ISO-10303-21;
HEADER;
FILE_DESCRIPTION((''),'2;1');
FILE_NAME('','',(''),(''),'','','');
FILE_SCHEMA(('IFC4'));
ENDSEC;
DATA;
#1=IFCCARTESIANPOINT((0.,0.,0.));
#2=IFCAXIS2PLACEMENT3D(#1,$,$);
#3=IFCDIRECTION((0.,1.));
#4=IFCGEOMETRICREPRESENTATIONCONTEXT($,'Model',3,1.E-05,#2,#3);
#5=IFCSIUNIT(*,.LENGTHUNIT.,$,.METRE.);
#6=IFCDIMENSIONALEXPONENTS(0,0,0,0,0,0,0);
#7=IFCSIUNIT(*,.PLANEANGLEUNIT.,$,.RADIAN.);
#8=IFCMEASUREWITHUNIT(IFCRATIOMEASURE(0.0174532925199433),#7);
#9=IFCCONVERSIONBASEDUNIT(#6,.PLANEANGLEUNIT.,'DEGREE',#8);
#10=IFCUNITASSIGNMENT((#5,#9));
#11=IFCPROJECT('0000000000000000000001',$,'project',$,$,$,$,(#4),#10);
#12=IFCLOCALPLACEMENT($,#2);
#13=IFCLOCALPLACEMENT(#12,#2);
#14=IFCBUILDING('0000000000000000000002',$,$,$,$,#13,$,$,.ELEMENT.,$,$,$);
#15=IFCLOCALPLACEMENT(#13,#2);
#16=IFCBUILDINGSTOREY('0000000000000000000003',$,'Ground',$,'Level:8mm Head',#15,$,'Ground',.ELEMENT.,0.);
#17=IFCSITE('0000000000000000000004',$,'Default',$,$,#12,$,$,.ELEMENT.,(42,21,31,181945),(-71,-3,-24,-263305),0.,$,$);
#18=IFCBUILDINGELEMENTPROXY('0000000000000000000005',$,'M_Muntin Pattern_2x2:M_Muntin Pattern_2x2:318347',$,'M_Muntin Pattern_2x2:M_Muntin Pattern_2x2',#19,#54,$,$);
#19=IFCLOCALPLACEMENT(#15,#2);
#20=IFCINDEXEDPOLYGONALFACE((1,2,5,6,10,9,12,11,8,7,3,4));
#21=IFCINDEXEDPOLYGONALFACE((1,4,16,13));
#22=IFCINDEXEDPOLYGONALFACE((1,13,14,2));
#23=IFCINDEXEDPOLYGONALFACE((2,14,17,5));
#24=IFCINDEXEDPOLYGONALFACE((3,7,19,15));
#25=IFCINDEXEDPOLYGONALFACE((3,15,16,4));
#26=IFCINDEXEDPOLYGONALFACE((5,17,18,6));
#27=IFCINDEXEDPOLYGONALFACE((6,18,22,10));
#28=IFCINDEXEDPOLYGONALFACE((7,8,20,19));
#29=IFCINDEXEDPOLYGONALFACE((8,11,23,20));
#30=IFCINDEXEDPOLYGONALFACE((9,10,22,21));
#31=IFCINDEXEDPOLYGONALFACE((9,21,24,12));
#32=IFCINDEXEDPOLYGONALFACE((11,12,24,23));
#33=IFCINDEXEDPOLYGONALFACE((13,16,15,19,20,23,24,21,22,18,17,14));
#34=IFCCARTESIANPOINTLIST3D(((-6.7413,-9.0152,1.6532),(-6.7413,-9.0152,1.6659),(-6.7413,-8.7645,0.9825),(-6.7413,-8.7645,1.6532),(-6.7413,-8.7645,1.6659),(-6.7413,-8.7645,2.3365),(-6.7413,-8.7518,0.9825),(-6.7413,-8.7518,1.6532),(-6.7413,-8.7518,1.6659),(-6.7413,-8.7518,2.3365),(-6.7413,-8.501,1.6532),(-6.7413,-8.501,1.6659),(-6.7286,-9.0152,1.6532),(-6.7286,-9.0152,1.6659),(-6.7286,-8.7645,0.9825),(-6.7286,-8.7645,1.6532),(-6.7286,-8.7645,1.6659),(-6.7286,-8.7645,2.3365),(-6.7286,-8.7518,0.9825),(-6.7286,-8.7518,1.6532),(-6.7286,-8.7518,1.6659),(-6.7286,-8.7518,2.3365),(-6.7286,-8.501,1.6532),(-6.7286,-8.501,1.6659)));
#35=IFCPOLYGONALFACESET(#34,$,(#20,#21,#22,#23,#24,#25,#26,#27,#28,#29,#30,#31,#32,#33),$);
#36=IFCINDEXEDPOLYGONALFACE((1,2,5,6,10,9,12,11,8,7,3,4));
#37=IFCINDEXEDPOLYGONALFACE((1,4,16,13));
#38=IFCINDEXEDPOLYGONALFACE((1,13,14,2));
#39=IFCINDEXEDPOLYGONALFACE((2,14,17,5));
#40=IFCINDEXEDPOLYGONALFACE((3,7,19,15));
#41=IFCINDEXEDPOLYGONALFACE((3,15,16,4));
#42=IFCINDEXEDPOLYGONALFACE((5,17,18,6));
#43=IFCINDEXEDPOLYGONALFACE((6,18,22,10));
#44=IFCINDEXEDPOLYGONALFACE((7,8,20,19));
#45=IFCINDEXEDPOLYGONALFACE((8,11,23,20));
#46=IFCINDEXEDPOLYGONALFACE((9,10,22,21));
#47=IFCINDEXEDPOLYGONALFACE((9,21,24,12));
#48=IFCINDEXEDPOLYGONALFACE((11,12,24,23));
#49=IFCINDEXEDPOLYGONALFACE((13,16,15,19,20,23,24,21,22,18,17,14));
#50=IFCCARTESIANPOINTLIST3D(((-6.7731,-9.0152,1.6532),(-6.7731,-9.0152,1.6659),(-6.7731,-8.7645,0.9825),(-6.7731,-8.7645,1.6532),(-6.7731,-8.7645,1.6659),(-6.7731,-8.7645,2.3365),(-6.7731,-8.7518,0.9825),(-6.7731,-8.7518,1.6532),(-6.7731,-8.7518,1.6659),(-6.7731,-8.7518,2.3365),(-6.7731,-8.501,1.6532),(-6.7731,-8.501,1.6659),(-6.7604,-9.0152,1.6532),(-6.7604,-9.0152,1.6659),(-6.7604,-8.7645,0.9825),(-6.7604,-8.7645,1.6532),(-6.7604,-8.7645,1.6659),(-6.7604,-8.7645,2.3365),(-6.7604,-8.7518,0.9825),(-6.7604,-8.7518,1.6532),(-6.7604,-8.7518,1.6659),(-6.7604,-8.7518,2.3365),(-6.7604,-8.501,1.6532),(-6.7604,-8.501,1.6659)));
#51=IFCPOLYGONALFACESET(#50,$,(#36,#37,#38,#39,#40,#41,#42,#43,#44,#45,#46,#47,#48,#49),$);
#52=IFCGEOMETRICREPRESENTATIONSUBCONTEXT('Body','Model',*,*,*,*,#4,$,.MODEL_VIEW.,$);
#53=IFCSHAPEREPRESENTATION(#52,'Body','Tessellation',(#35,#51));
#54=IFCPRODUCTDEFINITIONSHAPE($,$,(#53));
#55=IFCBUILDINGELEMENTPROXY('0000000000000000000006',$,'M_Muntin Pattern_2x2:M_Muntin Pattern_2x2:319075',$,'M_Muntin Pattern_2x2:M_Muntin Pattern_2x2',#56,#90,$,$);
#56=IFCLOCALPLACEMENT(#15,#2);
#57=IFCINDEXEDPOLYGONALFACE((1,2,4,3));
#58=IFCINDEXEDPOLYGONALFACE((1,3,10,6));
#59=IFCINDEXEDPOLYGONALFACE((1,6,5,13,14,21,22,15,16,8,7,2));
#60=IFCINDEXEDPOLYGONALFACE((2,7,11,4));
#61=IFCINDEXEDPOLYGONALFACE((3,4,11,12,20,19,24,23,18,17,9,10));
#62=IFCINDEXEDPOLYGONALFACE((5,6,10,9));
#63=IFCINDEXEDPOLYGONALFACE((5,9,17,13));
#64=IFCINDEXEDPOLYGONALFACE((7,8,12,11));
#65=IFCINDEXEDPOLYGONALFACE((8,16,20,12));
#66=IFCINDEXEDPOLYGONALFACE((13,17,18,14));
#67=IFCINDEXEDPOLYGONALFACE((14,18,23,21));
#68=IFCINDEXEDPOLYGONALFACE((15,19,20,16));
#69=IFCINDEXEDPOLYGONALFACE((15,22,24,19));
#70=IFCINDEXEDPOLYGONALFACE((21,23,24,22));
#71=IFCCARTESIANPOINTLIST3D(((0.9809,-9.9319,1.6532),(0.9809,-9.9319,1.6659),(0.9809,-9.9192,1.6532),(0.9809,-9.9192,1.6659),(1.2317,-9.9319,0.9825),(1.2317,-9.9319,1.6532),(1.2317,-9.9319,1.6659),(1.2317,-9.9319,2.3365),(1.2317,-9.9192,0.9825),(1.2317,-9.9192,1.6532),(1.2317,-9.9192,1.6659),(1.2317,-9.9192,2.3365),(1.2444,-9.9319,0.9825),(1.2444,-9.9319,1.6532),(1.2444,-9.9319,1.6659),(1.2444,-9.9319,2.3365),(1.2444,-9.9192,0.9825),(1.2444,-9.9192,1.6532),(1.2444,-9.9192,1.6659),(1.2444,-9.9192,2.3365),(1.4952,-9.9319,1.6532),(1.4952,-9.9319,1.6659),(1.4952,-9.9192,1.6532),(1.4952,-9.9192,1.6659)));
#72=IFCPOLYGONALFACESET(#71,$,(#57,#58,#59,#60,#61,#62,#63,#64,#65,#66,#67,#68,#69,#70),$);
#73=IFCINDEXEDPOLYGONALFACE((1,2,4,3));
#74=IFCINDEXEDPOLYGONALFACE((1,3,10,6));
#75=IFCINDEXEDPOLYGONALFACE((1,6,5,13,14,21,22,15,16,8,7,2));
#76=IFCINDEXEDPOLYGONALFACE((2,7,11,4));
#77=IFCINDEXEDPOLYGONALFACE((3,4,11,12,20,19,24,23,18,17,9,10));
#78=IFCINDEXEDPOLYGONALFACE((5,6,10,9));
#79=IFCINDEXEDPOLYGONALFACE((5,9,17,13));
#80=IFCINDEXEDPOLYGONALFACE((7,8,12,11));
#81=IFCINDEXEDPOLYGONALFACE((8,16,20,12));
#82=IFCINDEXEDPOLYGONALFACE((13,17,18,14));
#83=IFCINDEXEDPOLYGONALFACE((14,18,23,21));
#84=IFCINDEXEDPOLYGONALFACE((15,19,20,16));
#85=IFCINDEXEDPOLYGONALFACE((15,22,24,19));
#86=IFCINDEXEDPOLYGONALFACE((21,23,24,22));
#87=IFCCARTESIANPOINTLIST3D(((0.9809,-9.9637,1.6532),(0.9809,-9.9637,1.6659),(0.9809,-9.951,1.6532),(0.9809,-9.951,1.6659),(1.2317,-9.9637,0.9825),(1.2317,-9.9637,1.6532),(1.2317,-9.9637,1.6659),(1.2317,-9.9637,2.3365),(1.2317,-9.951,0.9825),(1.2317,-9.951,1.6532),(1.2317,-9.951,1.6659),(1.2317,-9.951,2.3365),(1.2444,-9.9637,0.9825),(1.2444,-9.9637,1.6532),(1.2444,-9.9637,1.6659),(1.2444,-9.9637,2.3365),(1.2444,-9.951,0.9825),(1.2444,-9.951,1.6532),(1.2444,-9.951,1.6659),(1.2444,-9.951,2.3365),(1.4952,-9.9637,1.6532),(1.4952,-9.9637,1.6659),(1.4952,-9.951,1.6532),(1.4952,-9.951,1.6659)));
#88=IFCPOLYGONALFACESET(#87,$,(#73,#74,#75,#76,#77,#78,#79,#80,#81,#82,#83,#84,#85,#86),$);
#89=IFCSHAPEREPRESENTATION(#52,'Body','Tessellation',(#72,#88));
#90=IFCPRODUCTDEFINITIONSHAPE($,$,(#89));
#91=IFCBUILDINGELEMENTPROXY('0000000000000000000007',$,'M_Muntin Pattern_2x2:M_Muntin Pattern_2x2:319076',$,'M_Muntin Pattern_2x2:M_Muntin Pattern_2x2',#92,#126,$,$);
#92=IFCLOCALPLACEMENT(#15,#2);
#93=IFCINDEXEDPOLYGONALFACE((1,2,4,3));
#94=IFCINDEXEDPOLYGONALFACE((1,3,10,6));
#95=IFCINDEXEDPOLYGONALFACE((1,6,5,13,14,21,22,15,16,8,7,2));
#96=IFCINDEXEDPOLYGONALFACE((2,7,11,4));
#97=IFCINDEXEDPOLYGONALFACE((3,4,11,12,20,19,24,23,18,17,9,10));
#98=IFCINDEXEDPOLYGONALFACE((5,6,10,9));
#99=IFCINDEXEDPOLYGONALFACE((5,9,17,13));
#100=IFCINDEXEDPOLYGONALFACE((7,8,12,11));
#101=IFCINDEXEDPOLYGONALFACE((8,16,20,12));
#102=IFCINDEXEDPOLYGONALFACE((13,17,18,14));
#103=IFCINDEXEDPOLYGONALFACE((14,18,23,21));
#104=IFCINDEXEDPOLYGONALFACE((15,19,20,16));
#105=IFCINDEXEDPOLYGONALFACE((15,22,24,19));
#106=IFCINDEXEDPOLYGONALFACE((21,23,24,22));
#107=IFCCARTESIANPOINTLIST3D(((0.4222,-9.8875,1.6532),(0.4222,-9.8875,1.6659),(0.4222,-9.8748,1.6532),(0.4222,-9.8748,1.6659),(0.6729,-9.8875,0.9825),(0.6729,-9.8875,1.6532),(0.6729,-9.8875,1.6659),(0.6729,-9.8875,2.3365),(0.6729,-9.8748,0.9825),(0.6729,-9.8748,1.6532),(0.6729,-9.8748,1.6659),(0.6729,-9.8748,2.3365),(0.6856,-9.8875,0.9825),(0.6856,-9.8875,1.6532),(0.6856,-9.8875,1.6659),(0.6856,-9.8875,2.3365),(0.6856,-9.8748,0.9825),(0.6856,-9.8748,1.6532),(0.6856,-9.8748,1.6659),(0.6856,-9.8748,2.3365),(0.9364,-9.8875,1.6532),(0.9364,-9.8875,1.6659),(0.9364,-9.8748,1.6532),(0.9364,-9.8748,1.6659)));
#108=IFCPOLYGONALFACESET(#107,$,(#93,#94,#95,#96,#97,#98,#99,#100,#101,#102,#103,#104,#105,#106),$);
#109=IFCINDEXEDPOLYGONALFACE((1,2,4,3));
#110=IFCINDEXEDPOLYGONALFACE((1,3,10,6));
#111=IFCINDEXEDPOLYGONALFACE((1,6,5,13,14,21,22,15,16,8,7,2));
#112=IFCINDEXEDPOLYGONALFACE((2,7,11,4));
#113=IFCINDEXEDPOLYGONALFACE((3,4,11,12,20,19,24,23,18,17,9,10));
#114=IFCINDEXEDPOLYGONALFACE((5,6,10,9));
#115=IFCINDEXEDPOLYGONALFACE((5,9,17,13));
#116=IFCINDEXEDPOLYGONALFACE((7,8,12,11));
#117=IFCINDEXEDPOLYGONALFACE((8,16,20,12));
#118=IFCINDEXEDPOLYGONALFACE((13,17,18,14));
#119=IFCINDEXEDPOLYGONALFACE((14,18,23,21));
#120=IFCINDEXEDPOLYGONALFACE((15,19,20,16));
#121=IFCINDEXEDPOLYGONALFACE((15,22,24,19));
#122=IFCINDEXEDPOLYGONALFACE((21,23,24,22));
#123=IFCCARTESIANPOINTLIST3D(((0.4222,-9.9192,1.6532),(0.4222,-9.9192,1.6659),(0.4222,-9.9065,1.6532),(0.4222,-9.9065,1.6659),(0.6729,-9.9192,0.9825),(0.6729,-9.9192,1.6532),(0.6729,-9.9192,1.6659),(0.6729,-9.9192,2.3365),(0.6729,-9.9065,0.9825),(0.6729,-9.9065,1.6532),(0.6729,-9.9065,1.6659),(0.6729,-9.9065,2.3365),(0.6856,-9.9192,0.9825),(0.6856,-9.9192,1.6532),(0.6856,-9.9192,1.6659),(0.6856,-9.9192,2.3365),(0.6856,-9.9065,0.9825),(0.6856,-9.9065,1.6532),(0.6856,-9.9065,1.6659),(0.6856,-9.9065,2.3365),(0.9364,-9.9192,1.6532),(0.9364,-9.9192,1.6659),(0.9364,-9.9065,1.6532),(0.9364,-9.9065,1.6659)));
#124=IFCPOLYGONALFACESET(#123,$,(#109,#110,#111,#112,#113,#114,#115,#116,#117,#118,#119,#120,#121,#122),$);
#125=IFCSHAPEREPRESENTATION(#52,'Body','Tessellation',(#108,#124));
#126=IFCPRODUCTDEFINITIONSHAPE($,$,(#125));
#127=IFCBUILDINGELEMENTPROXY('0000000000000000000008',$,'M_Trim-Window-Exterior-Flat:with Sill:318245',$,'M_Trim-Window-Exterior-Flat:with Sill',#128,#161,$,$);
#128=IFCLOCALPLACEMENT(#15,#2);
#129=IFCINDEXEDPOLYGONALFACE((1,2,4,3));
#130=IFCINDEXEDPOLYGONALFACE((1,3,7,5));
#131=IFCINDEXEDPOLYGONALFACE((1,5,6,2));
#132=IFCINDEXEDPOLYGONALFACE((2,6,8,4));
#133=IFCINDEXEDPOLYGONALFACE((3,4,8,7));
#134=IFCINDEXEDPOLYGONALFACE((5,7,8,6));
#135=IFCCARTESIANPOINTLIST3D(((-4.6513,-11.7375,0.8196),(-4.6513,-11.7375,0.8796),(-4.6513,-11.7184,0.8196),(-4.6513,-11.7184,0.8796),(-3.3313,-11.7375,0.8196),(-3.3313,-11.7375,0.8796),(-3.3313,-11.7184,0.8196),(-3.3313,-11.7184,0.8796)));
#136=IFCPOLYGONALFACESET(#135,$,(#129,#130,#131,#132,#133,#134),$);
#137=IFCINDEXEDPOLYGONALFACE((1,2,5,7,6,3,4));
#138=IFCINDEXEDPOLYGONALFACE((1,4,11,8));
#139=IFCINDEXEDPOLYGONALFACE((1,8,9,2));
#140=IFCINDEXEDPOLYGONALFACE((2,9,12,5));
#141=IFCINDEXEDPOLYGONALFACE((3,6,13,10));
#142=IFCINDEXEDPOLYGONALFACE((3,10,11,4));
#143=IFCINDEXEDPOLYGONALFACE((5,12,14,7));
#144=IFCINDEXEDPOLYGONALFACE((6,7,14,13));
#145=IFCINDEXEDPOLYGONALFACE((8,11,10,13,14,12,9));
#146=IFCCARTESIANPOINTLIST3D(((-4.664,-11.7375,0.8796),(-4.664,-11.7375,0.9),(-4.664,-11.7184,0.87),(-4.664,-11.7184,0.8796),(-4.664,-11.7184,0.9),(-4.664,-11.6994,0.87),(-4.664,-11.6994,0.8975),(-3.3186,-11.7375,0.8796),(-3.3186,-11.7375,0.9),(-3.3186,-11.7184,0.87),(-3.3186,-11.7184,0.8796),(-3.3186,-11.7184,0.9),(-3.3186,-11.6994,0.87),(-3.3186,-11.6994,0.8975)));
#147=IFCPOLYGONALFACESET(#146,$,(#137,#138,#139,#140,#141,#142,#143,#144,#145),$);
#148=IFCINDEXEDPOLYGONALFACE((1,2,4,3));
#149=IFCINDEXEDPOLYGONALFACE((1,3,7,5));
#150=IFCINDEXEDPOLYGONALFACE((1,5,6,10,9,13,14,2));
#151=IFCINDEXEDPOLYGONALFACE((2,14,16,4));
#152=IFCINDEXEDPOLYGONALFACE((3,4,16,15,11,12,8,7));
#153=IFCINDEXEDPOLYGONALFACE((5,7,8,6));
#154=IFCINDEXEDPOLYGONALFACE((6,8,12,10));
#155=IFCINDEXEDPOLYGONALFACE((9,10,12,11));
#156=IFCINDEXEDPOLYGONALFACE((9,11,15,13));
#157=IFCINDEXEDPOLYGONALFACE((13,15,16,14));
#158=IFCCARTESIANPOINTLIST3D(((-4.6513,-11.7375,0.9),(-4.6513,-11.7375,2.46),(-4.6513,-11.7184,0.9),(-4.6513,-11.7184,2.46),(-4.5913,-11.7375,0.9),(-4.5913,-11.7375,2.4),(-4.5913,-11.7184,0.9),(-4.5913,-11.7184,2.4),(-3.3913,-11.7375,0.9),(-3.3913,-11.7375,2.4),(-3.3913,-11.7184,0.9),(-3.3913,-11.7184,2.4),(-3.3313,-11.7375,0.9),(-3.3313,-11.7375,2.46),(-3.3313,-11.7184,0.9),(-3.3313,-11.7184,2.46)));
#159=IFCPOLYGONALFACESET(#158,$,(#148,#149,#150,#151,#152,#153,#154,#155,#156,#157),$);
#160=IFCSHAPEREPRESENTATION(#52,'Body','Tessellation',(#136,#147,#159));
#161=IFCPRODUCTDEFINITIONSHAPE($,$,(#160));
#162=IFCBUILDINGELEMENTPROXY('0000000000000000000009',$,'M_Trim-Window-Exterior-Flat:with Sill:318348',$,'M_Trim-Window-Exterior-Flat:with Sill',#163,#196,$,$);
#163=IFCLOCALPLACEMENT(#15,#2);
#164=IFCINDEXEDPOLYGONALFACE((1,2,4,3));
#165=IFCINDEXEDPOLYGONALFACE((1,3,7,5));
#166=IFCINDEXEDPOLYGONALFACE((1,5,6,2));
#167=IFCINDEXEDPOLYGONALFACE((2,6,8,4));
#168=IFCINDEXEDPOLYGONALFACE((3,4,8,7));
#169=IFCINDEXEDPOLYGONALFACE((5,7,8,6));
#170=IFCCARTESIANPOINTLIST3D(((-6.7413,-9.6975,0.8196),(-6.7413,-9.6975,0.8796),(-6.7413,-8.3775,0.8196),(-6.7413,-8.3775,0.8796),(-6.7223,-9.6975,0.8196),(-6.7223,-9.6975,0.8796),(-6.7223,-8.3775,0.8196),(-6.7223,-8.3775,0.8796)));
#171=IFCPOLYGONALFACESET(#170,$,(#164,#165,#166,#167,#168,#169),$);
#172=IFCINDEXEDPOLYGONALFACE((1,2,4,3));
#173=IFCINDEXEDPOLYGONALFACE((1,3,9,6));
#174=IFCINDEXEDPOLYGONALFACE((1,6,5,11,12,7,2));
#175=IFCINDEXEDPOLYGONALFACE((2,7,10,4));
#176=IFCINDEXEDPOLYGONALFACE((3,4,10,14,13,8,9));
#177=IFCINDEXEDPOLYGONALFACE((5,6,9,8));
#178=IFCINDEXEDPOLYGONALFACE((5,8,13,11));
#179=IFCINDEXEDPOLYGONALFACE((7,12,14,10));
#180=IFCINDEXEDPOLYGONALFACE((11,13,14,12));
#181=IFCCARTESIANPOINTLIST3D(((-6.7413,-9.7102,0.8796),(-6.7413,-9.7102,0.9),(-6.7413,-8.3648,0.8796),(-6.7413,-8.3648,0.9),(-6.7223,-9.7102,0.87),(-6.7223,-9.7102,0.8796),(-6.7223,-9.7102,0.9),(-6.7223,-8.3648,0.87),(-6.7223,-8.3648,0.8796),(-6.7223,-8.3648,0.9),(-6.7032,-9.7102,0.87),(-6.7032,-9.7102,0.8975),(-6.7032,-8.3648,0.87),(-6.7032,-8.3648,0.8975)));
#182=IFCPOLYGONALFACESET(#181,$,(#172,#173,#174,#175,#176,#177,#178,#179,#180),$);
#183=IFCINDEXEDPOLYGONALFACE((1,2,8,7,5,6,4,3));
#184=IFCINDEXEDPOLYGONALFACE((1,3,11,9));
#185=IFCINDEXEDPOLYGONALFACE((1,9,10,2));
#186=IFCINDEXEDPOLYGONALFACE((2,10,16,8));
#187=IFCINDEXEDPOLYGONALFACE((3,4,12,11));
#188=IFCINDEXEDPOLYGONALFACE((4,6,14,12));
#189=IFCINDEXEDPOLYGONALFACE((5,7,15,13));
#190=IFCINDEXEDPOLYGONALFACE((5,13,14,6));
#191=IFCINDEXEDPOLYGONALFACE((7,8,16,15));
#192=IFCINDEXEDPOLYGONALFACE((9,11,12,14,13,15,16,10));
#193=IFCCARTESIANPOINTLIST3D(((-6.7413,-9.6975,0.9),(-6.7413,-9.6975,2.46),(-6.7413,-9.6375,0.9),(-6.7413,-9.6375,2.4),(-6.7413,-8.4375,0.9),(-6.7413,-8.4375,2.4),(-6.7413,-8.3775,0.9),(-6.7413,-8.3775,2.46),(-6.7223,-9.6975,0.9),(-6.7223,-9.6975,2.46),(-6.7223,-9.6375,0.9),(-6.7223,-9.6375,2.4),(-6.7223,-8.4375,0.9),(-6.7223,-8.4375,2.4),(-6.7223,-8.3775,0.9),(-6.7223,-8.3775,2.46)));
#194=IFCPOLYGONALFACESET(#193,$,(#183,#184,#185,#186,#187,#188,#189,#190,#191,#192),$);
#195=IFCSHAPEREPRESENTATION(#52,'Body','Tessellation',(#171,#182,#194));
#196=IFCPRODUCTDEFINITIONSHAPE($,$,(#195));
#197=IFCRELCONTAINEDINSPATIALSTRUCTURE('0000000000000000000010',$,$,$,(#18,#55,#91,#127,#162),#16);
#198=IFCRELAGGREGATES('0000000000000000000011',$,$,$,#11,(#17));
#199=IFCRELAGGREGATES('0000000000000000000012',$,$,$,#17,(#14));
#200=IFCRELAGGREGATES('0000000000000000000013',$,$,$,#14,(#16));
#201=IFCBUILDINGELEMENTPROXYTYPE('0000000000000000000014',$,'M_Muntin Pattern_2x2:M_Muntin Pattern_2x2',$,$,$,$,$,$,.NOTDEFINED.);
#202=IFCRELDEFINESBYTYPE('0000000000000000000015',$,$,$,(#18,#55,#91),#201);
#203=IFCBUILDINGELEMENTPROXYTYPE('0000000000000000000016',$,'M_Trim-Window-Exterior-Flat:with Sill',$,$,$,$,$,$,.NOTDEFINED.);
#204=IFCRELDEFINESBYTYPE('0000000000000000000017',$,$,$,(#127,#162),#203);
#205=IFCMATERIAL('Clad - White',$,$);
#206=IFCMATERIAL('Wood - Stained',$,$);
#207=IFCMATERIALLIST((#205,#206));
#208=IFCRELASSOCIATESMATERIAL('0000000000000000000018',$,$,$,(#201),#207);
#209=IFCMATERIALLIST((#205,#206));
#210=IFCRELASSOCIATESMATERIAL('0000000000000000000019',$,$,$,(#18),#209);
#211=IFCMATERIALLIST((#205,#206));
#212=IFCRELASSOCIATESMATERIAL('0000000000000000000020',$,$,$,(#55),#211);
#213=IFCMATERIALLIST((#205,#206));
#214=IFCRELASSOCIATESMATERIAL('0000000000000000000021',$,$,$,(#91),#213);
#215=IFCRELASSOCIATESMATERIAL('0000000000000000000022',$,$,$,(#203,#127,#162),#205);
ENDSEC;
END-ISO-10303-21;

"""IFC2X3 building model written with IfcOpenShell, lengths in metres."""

from ifc_helpers import new_model, entity, si_unit, converted_unit, direction, frame, frame_2d, origin, place, context, subcontext, project, spatial, polyline, rectangle, outline, extrude, source, transform, mapped, material, material_list, type_object, type_shapes, element, save


model = new_model("IFC2X3")

# Units and contexts
model_context = context("Model", 3, precision=1e-05, world=origin(), true_north=direction((0.0, 1.0)))
body_context = subcontext(model_context, "Body", "Model", "MODEL_VIEW")
ifc_project = project(units=[si_unit("LENGTHUNIT", "METRE"), converted_unit("PLANEANGLEUNIT", "DEGREE", entity("IfcRatioMeasure", 0.0174532925199433), si_unit("PLANEANGLEUNIT", "RADIAN"), dimensions=[0, 0, 0, 0, 0, 0, 0])], contexts=[model_context])

# Site, building, storey
site_placement = place(None, origin())
site = spatial("IfcSite", under=ifc_project, at=site_placement, Name="Default", CompositionType="ELEMENT", RefLatitude=(42, 21, 31, 181945), RefLongitude=(-71, -3, -24, -263305), RefElevation=0.0)
building_placement = place(site_placement, origin())
building = spatial("IfcBuilding", under=site, at=building_placement, CompositionType="ELEMENT")
storey_placement = place(building_placement, origin())
storey = spatial("IfcBuildingStorey", under=building, at=storey_placement, Name="Ground", ObjectType="Level:8mm Head", LongName="Ground", CompositionType="ELEMENT", Elevation=0.0)

# Building element proxies
ifc_material_1 = material(Name="Clad - White")
ifc_material_2 = material(Name="Wood - Stained")
ifc_material_list_1 = material_list([ifc_material_1, ifc_material_2])
building_element_proxy_type_1 = type_object("IfcBuildingElementProxyType", Name="M_Muntin Pattern_2x2:M_Muntin Pattern_2x2", PredefinedType="NOTDEFINED", material=ifc_material_list_1)
shared_shape_1 = source(origin(), body_context, "Body", "SweptSolid", [
    extrude(outline(polyline([(0.0064, -0.0064), (0.677, -0.0064), (0.677, 0.0063), (0.0064, 0.0063), (0.0064, 0.2571), (-0.0063, 0.2571), (-0.0063, 0.0063), (-0.677, 0.0063), (-0.677, -0.0064), (-0.0063, -0.0064), (-0.0063, -0.2571), (0.0064, -0.2571), (0.0064, -0.0064)])), frame((0.0, 0.0095, 0.677), z_axis=(0.0, 1.0, 0.0), x_axis=(0.0, 0.0, 1.0)), (0.0, 0.0, 1.0), 0.0127),
    extrude(outline(polyline([(0.0064, -0.0064), (0.677, -0.0064), (0.677, 0.0063), (0.0064, 0.0063), (0.0064, 0.2571), (-0.0063, 0.2571), (-0.0063, 0.0063), (-0.677, 0.0063), (-0.677, -0.0064), (-0.0063, -0.0064), (-0.0063, -0.2571), (0.0064, -0.2571), (0.0064, -0.0064)])), frame((0.0, -0.0222, 0.677), z_axis=(0.0, 1.0, 0.0), x_axis=(0.0, 0.0, 1.0)), (0.0, 0.0, 1.0), 0.0127),
])
type_shapes(building_element_proxy_type_1, [shared_shape_1])
ifc_material_list_2 = material_list([ifc_material_1, ifc_material_2])
proxy_1_placement = place(storey_placement, frame((-6.7509, -8.7581, 0.9825), z_axis=(0.0, 0.0, 1.0), x_axis=(0.0, -1.0, 0.0)))
element("IfcBuildingElementProxy", 1, at=proxy_1_placement, inside=storey, type_object=building_element_proxy_type_1, material=ifc_material_list_2, Name="M_Muntin Pattern_2x2:M_Muntin Pattern_2x2:318347", ObjectType="M_Muntin Pattern_2x2:M_Muntin Pattern_2x2", context=body_context, shape_type="MappedRepresentation", body=[
    mapped(shared_shape_1, transform((0.0, 0.0, 0.0), scale=1.0)),
])
ifc_material_list_3 = material_list([ifc_material_1, ifc_material_2])
proxy_2_placement = place(storey_placement, frame((1.238, -9.9414, 0.9825)))
element("IfcBuildingElementProxy", 2, at=proxy_2_placement, inside=storey, type_object=building_element_proxy_type_1, material=ifc_material_list_3, Name="M_Muntin Pattern_2x2:M_Muntin Pattern_2x2:319075", ObjectType="M_Muntin Pattern_2x2:M_Muntin Pattern_2x2", context=body_context, shape_type="MappedRepresentation", body=[
    mapped(shared_shape_1, transform((0.0, 0.0, 0.0), scale=1.0)),
])
ifc_material_list_4 = material_list([ifc_material_1, ifc_material_2])
proxy_3_placement = place(storey_placement, frame((0.6793, -9.897, 0.9825)))
element("IfcBuildingElementProxy", 3, at=proxy_3_placement, inside=storey, type_object=building_element_proxy_type_1, material=ifc_material_list_4, Name="M_Muntin Pattern_2x2:M_Muntin Pattern_2x2:319076", ObjectType="M_Muntin Pattern_2x2:M_Muntin Pattern_2x2", context=body_context, shape_type="MappedRepresentation", body=[
    mapped(shared_shape_1, transform((0.0, 0.0, 0.0), scale=1.0)),
])
building_element_proxy_type_2 = type_object("IfcBuildingElementProxyType", Name="M_Trim-Window-Exterior-Flat:with Sill", PredefinedType="NOTDEFINED", material=ifc_material_1)
shared_shape_2 = source(origin(), body_context, "Body", "SweptSolid", [
    extrude(rectangle(XDim=1.32, YDim=0.06, at=frame_2d((0.0, 0.0), x_axis=(1.0, 0.0))), frame((0.0, -1.5504, 0.0), z_axis=(0.0, 0.0, 1.0), x_axis=(-1.0, 0.0, 0.0)), (0.0, 0.0, 1.0), 0.0191),
    extrude(outline(polyline([(-0.019, -0.0152), (0.0, -0.0152), (0.0, -0.0057), (0.019, -0.0057), (0.019, 0.0148), (0.0, 0.0148), (-0.019, 0.0123), (-0.019, -0.0152)])), frame((-0.6727, -1.5148, 0.019), z_axis=(1.0, 0.0, 0.0), x_axis=(0.0, 0.0, -1.0)), (0.0, 0.0, 1.0), 1.3454),
    extrude(outline(polyline([(-0.795, -0.66), (0.765, -0.66), (0.765, -0.6), (-0.735, -0.6), (-0.735, 0.6), (0.765, 0.6), (0.765, 0.66), (-0.795, 0.66), (-0.795, -0.66)])), frame((0.0, -0.735, 0.0), z_axis=(0.0, 0.0, 1.0), x_axis=(0.0, -1.0, 0.0)), (0.0, 0.0, 1.0), 0.0191),
])
type_shapes(building_element_proxy_type_2, [shared_shape_2])
for number, where, z_axis, x_axis, name in (
    (4, (-3.9913, -11.7375, 2.4), (0.0, 1.0, 0.0), (-1.0, 0.0, 0.0), "M_Trim-Window-Exterior-Flat:with Sill:318245"),
    (5, (-6.7413, -9.0375, 2.4), (1.0, 0.0, 0.0), (0.0, 1.0, 0.0), "M_Trim-Window-Exterior-Flat:with Sill:318348"),
):
    element("IfcBuildingElementProxy", number, at=place(storey_placement, frame(where, z_axis=z_axis, x_axis=x_axis)), inside=storey, type_object=building_element_proxy_type_2, material=ifc_material_1, Name=name, ObjectType="M_Trim-Window-Exterior-Flat:with Sill", context=body_context, shape_type="MappedRepresentation", body=[
        mapped(shared_shape_2, transform((0.0, 0.0, 0.0), scale=1.0)),
    ])

save(model, "model.ifc")
